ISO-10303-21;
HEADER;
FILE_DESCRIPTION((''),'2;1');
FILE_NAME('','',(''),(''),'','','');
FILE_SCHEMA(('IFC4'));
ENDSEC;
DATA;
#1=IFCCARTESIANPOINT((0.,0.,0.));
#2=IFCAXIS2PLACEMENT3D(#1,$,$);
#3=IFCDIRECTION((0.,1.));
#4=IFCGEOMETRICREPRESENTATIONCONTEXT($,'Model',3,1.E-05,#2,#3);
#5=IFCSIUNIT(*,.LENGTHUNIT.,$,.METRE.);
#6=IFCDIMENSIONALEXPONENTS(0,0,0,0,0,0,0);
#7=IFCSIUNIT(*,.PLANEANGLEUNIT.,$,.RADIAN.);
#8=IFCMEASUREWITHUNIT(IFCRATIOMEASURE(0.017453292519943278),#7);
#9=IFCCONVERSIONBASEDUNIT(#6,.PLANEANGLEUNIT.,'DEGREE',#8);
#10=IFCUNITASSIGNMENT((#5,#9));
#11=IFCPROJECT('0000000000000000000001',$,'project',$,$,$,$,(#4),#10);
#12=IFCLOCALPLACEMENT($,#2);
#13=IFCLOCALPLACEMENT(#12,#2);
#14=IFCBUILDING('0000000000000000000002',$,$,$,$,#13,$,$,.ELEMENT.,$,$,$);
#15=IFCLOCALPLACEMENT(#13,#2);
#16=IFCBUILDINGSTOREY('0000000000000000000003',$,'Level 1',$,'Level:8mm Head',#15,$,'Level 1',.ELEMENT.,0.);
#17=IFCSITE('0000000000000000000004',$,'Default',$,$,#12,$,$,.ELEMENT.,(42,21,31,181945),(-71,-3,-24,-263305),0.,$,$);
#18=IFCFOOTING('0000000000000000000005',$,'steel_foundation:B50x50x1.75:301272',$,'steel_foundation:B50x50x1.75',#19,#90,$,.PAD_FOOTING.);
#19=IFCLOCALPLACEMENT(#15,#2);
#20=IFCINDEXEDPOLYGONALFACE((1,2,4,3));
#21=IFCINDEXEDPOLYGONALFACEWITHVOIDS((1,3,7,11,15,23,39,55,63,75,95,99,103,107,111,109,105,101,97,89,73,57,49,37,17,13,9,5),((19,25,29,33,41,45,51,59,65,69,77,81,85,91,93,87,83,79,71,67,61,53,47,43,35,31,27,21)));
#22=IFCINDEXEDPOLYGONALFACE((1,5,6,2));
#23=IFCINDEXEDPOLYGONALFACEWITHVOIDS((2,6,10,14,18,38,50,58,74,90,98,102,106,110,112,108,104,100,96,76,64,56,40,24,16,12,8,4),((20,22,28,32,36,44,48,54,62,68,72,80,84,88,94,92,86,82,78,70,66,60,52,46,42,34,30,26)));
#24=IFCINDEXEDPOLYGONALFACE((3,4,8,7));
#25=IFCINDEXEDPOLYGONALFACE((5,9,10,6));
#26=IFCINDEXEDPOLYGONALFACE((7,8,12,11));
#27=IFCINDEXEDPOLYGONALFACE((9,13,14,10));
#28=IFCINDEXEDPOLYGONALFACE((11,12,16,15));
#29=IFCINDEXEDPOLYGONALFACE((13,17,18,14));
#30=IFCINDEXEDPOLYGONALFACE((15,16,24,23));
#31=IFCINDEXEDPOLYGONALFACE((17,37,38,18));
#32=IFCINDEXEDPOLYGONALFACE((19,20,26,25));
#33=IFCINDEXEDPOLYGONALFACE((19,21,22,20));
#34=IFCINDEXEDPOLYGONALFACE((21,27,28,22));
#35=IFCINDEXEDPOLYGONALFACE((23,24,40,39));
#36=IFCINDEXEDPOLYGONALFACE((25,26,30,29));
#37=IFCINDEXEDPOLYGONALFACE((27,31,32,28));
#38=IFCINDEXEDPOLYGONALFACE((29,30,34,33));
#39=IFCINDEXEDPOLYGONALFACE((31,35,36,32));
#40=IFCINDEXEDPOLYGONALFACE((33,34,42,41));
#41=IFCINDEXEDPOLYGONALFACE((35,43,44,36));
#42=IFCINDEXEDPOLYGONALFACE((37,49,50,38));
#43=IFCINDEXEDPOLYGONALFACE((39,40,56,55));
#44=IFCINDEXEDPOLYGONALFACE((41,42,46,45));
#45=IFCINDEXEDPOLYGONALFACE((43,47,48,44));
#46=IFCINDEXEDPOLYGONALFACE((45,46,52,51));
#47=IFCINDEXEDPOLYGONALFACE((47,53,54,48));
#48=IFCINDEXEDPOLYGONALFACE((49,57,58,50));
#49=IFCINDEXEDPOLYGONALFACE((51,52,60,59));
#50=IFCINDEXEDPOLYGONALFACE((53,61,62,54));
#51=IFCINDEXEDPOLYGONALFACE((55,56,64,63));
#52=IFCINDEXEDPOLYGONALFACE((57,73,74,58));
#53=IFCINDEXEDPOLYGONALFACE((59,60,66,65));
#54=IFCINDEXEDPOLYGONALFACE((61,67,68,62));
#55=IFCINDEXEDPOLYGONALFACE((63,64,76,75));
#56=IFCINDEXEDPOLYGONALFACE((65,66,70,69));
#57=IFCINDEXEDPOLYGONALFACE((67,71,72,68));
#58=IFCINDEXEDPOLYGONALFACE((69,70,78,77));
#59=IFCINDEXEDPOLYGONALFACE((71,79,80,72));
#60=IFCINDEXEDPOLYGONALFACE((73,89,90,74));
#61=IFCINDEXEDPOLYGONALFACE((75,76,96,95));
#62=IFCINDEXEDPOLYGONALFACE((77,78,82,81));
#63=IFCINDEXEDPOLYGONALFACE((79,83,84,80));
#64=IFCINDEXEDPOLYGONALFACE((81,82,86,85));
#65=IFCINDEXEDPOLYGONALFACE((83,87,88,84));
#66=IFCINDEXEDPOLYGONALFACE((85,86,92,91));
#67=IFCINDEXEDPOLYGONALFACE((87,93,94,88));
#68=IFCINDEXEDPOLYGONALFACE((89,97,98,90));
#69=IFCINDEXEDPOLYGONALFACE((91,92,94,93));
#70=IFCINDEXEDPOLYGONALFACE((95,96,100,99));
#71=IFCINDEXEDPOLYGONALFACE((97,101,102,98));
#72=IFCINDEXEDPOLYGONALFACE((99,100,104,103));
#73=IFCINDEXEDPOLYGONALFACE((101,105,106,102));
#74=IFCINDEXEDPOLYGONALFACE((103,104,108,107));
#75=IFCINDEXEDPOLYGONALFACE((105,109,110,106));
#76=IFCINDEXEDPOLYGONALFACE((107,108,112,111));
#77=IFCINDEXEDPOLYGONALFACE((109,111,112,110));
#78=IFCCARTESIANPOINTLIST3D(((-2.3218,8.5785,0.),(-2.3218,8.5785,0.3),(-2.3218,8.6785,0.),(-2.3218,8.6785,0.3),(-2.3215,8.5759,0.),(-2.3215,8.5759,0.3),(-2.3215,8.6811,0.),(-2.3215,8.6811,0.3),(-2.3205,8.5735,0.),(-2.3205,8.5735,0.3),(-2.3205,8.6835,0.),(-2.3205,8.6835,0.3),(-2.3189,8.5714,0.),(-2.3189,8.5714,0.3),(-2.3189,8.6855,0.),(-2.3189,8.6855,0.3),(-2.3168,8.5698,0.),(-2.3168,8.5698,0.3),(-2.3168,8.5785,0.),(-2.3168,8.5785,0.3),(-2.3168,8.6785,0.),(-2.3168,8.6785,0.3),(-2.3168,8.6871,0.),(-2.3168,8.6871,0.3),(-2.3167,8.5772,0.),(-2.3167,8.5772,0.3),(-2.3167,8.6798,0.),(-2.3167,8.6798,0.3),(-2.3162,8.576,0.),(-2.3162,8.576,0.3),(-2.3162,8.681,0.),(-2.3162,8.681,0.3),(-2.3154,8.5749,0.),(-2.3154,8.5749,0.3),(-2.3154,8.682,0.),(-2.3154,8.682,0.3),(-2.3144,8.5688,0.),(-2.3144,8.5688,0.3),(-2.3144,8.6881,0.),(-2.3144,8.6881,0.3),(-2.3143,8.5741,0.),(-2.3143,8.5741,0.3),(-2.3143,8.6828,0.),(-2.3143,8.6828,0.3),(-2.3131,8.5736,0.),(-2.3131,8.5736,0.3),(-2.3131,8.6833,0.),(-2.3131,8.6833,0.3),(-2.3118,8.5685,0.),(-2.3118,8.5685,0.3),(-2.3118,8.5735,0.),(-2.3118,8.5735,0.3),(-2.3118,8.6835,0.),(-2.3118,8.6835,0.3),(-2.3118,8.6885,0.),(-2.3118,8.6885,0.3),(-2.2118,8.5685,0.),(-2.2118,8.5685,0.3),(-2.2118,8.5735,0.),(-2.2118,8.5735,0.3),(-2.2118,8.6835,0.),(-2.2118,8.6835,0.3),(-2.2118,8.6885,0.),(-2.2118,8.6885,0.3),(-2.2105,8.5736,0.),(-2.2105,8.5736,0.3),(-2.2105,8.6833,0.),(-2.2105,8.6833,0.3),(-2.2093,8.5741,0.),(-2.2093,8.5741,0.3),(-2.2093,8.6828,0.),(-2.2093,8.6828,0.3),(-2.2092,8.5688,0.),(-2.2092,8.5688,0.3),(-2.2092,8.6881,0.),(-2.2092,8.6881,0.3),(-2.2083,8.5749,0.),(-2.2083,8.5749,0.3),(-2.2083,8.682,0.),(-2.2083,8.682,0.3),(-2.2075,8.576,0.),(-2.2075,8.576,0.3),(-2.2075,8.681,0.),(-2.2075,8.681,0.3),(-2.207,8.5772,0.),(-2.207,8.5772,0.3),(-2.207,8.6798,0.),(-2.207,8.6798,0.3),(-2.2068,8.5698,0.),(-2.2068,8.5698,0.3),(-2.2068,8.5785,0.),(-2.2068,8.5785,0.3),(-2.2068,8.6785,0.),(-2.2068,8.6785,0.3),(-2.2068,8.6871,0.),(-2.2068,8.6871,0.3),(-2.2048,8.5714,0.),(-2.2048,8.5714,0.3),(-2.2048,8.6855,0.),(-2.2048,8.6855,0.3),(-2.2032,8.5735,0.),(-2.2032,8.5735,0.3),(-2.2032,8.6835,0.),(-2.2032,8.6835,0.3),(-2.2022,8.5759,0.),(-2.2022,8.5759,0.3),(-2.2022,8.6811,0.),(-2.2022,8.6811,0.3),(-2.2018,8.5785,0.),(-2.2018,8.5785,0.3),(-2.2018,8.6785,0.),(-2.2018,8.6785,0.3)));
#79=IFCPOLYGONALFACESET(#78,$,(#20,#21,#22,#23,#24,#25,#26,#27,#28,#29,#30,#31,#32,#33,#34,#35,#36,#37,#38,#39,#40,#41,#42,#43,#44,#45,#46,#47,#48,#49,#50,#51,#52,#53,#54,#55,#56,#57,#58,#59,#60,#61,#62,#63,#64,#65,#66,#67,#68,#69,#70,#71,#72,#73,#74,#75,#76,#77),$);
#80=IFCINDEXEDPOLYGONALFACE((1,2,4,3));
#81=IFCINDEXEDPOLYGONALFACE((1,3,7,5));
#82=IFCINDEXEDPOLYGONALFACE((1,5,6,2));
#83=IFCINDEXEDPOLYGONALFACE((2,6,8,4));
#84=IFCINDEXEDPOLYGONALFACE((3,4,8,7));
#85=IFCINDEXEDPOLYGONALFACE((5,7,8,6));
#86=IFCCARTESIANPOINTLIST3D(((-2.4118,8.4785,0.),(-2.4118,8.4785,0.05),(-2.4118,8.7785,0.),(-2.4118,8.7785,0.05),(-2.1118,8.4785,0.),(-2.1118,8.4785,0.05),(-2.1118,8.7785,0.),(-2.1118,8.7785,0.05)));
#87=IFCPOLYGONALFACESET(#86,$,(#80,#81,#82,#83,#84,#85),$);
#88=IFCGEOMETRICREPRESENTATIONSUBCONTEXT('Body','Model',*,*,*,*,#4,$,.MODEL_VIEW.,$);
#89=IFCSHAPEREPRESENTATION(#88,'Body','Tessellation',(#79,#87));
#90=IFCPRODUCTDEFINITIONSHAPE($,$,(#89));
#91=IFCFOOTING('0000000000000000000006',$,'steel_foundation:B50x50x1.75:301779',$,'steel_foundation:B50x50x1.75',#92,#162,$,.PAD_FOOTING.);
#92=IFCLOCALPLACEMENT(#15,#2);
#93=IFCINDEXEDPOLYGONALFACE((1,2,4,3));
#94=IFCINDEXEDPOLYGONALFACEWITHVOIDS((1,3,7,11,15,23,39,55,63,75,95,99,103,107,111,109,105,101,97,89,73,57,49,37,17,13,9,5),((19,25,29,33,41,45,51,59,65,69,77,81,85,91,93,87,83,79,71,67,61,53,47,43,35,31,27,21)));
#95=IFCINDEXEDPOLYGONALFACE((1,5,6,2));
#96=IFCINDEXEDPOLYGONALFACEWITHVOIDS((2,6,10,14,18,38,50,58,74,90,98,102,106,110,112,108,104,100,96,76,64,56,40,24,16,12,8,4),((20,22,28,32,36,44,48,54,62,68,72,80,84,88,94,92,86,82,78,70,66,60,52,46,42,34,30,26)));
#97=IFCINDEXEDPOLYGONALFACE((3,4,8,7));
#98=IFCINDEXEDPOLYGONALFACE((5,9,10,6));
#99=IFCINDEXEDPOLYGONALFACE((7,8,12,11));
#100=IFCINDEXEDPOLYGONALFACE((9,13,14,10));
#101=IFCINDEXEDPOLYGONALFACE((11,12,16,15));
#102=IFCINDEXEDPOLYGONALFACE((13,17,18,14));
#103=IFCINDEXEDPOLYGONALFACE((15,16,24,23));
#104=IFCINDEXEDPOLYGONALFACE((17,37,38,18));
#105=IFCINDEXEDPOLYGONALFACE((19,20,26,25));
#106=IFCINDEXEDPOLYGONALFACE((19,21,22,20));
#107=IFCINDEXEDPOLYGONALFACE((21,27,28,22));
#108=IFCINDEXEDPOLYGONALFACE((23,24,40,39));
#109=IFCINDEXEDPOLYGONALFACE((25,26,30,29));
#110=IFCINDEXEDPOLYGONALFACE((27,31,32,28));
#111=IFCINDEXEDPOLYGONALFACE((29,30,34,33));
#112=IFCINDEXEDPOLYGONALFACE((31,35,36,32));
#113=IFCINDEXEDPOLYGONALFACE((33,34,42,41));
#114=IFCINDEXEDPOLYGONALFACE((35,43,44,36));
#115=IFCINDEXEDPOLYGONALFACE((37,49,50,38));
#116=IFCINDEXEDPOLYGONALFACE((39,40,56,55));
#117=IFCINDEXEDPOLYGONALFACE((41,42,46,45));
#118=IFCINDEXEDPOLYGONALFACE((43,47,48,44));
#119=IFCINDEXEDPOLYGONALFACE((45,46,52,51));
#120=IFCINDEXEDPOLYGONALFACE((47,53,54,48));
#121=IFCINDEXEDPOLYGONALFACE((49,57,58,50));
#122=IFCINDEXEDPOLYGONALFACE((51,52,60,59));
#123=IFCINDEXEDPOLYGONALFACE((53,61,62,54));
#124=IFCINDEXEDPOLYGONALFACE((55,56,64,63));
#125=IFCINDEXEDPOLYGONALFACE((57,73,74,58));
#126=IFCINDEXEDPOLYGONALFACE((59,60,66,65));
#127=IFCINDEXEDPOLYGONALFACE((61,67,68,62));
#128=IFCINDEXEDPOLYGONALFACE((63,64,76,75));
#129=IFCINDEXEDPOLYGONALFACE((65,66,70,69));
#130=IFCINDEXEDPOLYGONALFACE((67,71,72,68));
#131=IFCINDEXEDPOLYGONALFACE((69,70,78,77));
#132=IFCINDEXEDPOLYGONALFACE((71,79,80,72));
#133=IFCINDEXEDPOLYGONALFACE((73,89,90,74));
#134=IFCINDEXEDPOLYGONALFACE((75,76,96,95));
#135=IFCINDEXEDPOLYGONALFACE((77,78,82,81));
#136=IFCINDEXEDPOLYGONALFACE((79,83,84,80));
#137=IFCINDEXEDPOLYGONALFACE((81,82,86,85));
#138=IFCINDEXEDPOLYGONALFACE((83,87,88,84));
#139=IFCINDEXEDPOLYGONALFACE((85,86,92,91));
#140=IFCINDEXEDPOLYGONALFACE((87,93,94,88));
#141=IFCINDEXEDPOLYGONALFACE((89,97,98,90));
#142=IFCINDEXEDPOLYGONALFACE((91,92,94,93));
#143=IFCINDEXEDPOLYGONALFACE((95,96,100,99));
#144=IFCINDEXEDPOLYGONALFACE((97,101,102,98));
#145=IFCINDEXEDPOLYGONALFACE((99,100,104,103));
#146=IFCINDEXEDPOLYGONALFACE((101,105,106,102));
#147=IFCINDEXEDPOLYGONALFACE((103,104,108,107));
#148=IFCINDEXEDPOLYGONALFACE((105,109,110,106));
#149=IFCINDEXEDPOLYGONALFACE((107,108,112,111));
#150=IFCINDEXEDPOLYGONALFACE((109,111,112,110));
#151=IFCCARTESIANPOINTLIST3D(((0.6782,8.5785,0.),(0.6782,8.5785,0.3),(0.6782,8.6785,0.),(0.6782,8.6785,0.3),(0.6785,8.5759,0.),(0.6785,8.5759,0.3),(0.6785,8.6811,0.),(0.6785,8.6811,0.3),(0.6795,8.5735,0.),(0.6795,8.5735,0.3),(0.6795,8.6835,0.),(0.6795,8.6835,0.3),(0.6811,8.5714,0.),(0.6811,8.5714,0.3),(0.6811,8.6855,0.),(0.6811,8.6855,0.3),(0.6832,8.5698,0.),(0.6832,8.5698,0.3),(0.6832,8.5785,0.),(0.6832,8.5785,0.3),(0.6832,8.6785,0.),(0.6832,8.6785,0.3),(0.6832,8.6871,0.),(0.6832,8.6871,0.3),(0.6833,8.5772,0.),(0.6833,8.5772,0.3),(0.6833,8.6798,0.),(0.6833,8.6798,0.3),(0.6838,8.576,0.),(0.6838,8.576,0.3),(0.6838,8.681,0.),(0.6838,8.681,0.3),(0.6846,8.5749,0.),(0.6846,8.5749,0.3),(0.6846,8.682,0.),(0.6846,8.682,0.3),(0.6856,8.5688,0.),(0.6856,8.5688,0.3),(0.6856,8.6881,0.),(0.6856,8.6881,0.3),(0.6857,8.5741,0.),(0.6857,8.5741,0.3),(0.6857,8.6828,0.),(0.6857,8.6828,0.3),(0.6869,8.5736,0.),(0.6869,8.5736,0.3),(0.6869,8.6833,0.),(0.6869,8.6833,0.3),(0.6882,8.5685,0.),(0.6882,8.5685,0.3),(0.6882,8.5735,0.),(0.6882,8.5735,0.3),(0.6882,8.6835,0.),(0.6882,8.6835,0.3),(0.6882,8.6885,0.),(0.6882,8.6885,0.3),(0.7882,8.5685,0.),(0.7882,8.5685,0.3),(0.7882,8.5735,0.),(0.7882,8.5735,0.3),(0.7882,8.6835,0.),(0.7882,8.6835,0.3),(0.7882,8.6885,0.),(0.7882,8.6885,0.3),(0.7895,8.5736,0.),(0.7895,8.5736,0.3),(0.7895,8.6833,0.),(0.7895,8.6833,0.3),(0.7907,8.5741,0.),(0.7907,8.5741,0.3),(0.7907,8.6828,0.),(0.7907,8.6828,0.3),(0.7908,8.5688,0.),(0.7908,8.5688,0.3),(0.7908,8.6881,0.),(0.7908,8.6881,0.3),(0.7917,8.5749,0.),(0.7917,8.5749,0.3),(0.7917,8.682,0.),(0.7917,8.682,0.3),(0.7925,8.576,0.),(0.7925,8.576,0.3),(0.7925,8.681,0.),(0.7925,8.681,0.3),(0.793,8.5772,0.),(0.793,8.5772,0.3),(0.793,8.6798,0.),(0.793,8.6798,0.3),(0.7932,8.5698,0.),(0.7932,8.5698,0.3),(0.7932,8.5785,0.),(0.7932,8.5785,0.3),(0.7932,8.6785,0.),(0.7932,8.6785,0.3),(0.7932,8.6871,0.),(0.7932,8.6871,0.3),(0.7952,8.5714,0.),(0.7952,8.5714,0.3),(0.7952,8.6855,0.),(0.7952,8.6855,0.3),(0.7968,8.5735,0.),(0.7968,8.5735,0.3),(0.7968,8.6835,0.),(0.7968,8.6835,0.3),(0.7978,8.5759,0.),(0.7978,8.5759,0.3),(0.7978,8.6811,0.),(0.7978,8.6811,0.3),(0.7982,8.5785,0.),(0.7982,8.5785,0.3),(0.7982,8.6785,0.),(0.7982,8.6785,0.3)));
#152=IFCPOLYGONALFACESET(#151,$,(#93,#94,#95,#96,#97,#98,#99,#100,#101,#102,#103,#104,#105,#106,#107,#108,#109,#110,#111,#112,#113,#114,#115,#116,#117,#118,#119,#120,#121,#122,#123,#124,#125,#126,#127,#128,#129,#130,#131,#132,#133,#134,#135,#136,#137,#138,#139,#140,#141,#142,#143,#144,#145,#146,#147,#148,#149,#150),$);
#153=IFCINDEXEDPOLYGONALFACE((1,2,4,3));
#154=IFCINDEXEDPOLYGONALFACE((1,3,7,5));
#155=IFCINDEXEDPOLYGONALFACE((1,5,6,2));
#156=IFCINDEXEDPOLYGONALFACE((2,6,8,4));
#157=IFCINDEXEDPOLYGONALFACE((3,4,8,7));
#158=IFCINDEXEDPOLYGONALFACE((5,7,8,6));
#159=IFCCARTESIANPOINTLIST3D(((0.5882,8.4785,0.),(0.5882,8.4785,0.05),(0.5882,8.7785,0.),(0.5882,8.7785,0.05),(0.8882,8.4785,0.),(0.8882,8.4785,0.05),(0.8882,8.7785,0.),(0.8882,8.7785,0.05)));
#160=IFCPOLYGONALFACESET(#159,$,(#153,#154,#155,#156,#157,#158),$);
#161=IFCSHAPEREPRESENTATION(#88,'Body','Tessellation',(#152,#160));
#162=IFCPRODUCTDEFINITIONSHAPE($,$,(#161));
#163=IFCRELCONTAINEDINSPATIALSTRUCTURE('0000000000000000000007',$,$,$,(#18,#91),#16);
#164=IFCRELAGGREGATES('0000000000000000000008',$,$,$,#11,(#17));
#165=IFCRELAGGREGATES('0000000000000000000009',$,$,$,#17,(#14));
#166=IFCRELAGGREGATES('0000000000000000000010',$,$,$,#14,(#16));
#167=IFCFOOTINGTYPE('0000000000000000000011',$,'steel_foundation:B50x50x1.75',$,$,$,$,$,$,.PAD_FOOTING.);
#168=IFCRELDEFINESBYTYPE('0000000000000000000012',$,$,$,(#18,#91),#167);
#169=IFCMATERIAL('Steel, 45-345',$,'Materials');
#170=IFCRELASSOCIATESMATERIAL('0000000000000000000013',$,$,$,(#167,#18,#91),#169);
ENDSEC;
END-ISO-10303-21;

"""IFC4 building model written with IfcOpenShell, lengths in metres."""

from ifc_helpers import new_model, entity, si_unit, converted_unit, direction, frame, frame_2d, origin, place, context, subcontext, project, spatial, polyline, circle_curve, parameter, trimmed, segment, composite_curve, rectangle, outline, extrude, source, transform, mapped, material, type_object, type_shapes, element, save


model = new_model("IFC4")

# Units and contexts
model_context = context("Model", 3, precision=1e-05, world=origin(), true_north=direction((0.0, 1.0)))
body_context = subcontext(model_context, "Body", "Model", "MODEL_VIEW")
ifc_project = project(units=[si_unit("LENGTHUNIT", "METRE"), converted_unit("PLANEANGLEUNIT", "DEGREE", entity("IfcRatioMeasure", 0.017453292519943278), si_unit("PLANEANGLEUNIT", "RADIAN"), dimensions=[0, 0, 0, 0, 0, 0, 0])], contexts=[model_context])

# Site, building, storey
site_placement = place(None, origin())
site = spatial("IfcSite", under=ifc_project, at=site_placement, Name="Default", CompositionType="ELEMENT", RefLatitude=(42, 21, 31, 181945), RefLongitude=(-71, -3, -24, -263305), RefElevation=0.0)
building_placement = place(site_placement, origin())
building = spatial("IfcBuilding", under=site, at=building_placement, CompositionType="ELEMENT")
storey_placement = place(building_placement, origin())
storey = spatial("IfcBuildingStorey", under=building, at=storey_placement, Name="Level 1", ObjectType="Level:8mm Head", LongName="Level 1", CompositionType="ELEMENT", Elevation=0.0)

# Footings
ifc_material_1 = material(Name="Steel, 45-345", Category="Materials")
footing_type = type_object("IfcFootingType", Name="steel_foundation:B50x50x1.75", PredefinedType="PAD_FOOTING", material=ifc_material_1)
shared_shape_1 = source(origin(), body_context, "Body", "SweptSolid", [
    extrude(outline(composite_curve([segment(polyline([(-0.05, -0.06), (0.05, -0.06)]), True, "CONTINUOUS"), segment(trimmed(circle_curve(frame_2d((0.05, -0.05), x_axis=(-1.0, 0.0)), 0.01), [parameter(90.0)], [parameter(180.0)], True, "PARAMETER"), True, "CONTINUOUS"), segment(polyline([(0.06, -0.05), (0.06, 0.05)]), True, "CONTINUOUS"), segment(trimmed(circle_curve(frame_2d((0.05, 0.05), x_axis=(-1.0, 0.0)), 0.01), [parameter(180.0)], [parameter(270.0)], True, "PARAMETER"), True, "CONTINUOUS"), segment(polyline([(0.05, 0.06), (-0.05, 0.06)]), True, "CONTINUOUS"), segment(trimmed(circle_curve(frame_2d((-0.05, 0.05), x_axis=(-1.0, 0.0)), 0.01), [parameter(270.0)], [parameter(360.0)], True, "PARAMETER"), True, "CONTINUOUS"), segment(polyline([(-0.06, 0.05), (-0.06, -0.05)]), True, "CONTINUOUS"), segment(trimmed(circle_curve(frame_2d((-0.05, -0.05), x_axis=(-1.0, 0.0)), 0.01), [parameter(360.0)], [parameter(90.0)], True, "PARAMETER"), True, "CONTINUOUS")], self_intersect=False), holes=[composite_curve([segment(trimmed(circle_curve(frame_2d((-0.05, -0.05), x_axis=(-1.0, 0.0)), 0.005), [parameter(0.0)], [parameter(90.0)], True, "PARAMETER"), False, "CONTINUOUS"), segment(polyline([(-0.055, -0.05), (-0.055, 0.05)]), True, "CONTINUOUS"), segment(trimmed(circle_curve(frame_2d((-0.05, 0.05), x_axis=(-1.0, 0.0)), 0.005), [parameter(270.0)], [parameter(360.0)], True, "PARAMETER"), False, "CONTINUOUS"), segment(polyline([(-0.05, 0.055), (0.05, 0.055)]), True, "CONTINUOUS"), segment(trimmed(circle_curve(frame_2d((0.05, 0.05), x_axis=(-1.0, 0.0)), 0.005), [parameter(180.0)], [parameter(270.0)], True, "PARAMETER"), False, "CONTINUOUS"), segment(polyline([(0.055, 0.05), (0.055, -0.05)]), True, "CONTINUOUS"), segment(trimmed(circle_curve(frame_2d((0.05, -0.05), x_axis=(-1.0, 0.0)), 0.005), [parameter(90.0)], [parameter(180.0)], True, "PARAMETER"), False, "CONTINUOUS"), segment(polyline([(0.05, -0.055), (-0.05, -0.055)]), True, "CONTINUOUS")], self_intersect=False)]), frame((0.0, 0.0, 0.0), z_axis=(0.0, 0.0, 1.0), x_axis=(-1.0, 0.0, 0.0)), (0.0, 0.0, 1.0), 0.3),
    extrude(rectangle(XDim=0.3, YDim=0.3, at=frame_2d((0.0, 0.0), x_axis=(1.0, 0.0))), frame((0.0, 0.0, 0.0), z_axis=(0.0, 0.0, 1.0), x_axis=(-1.0, 0.0, 0.0)), (0.0, 0.0, 1.0), 0.05),
])
type_shapes(footing_type, [shared_shape_1])
for number, where, name in (
    (1, (-2.2618, 8.6285, 0.0), "steel_foundation:B50x50x1.75:301272"),
    (2, (0.7382, 8.6285, 0.0), "steel_foundation:B50x50x1.75:301779"),
):
    element("IfcFooting", number, at=place(storey_placement, frame(where)), inside=storey, type_object=footing_type, material=ifc_material_1, Name=name, ObjectType="steel_foundation:B50x50x1.75", PredefinedType="PAD_FOOTING", context=body_context, shape_type="MappedRepresentation", body=[
        mapped(shared_shape_1, transform((0.0, 0.0, 0.0), scale=1.0)),
    ])

save(model, "model.ifc")
